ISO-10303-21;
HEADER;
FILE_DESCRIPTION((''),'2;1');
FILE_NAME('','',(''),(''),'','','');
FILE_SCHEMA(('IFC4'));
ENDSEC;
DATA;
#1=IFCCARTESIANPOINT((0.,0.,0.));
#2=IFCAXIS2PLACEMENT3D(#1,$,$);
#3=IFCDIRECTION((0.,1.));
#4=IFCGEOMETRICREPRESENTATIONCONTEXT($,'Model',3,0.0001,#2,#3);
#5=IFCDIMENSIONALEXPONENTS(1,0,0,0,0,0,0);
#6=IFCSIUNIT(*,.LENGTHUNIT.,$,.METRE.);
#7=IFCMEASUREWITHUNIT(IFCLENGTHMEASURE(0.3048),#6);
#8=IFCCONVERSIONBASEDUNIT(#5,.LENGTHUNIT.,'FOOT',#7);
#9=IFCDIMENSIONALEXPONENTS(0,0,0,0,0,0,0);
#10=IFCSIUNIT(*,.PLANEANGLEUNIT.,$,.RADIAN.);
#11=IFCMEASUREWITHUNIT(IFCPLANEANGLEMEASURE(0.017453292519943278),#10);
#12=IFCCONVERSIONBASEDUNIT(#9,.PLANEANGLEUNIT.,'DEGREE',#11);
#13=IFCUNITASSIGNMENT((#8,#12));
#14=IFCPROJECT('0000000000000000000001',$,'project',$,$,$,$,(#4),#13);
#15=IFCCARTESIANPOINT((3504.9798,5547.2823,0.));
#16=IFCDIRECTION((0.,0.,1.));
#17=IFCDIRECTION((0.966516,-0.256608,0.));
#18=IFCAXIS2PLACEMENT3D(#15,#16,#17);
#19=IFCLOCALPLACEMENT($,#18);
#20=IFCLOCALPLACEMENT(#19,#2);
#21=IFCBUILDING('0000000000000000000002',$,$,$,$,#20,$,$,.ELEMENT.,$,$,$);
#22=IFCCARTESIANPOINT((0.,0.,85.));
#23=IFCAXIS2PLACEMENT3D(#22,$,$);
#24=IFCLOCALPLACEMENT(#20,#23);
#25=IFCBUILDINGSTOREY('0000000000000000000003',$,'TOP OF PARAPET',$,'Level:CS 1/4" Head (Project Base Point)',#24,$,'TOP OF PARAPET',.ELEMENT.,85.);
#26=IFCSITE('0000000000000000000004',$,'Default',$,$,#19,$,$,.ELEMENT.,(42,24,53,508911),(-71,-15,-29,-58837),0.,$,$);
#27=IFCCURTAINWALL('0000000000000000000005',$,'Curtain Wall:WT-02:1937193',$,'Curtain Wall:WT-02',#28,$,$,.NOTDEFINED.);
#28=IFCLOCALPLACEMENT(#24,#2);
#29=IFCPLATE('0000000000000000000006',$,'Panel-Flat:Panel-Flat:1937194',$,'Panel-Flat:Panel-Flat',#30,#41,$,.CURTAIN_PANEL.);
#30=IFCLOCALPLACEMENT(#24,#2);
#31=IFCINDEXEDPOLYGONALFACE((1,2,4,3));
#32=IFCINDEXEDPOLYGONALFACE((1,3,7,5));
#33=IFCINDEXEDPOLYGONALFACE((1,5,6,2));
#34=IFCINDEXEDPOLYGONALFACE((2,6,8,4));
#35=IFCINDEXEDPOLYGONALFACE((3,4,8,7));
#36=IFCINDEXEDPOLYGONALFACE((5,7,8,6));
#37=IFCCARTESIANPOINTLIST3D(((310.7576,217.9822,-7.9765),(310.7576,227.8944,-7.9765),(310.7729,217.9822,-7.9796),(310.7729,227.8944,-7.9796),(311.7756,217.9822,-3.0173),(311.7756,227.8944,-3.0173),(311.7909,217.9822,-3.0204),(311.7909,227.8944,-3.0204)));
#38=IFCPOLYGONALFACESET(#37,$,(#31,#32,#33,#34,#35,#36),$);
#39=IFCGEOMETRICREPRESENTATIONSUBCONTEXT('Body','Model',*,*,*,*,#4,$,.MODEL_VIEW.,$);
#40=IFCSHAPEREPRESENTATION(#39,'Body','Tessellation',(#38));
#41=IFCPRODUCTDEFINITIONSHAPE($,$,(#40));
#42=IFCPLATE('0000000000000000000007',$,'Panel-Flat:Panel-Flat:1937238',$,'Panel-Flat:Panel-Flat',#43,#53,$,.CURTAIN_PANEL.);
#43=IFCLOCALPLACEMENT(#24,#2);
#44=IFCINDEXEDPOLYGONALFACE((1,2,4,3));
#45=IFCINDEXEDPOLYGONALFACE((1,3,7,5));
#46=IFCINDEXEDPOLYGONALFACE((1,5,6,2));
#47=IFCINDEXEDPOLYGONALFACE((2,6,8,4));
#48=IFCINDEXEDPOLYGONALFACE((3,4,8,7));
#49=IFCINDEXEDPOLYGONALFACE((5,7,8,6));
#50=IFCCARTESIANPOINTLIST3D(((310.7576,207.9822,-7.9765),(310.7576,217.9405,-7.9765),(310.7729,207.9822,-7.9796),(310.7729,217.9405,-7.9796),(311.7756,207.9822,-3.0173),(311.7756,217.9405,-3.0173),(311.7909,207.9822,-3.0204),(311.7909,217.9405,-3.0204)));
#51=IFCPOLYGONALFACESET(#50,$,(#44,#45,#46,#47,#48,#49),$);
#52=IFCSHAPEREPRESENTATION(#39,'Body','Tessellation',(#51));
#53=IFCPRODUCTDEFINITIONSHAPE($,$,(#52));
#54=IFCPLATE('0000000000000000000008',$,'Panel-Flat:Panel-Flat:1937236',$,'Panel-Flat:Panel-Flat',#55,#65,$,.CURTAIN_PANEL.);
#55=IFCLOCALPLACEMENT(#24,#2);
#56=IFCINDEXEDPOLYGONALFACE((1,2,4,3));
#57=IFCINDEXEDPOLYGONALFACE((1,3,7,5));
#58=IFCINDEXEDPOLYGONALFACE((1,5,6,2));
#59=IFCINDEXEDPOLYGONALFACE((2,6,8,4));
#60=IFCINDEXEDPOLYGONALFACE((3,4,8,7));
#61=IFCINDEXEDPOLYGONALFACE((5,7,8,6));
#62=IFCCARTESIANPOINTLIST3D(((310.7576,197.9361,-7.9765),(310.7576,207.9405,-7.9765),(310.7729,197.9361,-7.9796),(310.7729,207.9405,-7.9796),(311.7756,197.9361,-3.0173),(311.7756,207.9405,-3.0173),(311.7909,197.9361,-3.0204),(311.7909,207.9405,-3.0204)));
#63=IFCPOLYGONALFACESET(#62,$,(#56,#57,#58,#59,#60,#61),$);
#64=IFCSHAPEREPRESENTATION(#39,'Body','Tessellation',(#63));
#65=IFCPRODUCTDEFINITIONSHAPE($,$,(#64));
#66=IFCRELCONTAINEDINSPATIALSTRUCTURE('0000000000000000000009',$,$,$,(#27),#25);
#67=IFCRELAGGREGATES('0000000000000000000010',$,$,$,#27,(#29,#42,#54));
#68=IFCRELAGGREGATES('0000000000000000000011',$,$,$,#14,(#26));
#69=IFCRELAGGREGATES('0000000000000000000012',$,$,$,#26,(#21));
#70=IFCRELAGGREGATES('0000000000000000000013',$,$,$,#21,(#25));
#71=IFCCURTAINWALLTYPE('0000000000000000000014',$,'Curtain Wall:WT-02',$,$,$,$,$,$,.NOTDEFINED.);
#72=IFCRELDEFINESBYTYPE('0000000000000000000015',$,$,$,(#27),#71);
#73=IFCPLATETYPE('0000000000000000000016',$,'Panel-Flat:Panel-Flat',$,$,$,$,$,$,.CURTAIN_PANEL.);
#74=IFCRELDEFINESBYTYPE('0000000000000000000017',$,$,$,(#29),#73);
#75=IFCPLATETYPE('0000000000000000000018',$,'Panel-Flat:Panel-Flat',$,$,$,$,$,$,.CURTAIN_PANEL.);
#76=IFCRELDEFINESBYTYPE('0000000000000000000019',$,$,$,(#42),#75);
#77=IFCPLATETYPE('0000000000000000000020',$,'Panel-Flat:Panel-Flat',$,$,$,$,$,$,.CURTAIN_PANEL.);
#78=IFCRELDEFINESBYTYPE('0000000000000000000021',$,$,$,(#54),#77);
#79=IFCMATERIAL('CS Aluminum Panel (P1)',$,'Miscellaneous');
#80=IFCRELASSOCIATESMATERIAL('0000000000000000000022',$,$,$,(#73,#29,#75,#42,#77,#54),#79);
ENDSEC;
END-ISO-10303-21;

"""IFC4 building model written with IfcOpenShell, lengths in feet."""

from ifc_helpers import new_model, entity, si_unit, converted_unit, direction, frame, origin, place, context, subcontext, project, spatial, indexed_curve, outline, extrude, source, transform, mapped, material, type_object, type_shapes, element, aggregate, save


model = new_model("IFC4")

# Units and contexts
model_context = context("Model", 3, precision=0.0001, world=origin(), true_north=direction((0.0, 1.0)))
body_context = subcontext(model_context, "Body", "Model", "MODEL_VIEW")
ifc_project = project(units=[converted_unit("LENGTHUNIT", "FOOT", entity("IfcLengthMeasure", 0.3048), si_unit("LENGTHUNIT", "METRE"), dimensions=[1, 0, 0, 0, 0, 0, 0]), converted_unit("PLANEANGLEUNIT", "DEGREE", entity("IfcPlaneAngleMeasure", 0.017453292519943278), si_unit("PLANEANGLEUNIT", "RADIAN"), dimensions=[0, 0, 0, 0, 0, 0, 0])], contexts=[model_context])

# Site, building, storey
site_placement = place(None, frame((3504.9798, 5547.2823, 0.0), z_axis=(0.0, 0.0, 1.0), x_axis=(0.966516, -0.256608, 0.0)))
site = spatial("IfcSite", under=ifc_project, at=site_placement, Name="Default", CompositionType="ELEMENT", RefLatitude=(42, 24, 53, 508911), RefLongitude=(-71, -15, -29, -58837), RefElevation=0.0)
building_placement = place(site_placement, origin())
building = spatial("IfcBuilding", under=site, at=building_placement, CompositionType="ELEMENT")
storey_placement = place(building_placement, frame((0.0, 0.0, 85.0)))
storey = spatial("IfcBuildingStorey", under=building, at=storey_placement, Name="TOP OF PARAPET", ObjectType="Level:CS 1/4\" Head (Project Base Point)", LongName="TOP OF PARAPET", CompositionType="ELEMENT", Elevation=85.0)

# Shared definitions
curtain_wall_type_1 = type_object("IfcCurtainWallType", Name="Curtain Wall:WT-02", PredefinedType="NOTDEFINED")

# Curtain wall, plates
curtain_wall_1_placement = place(storey_placement, frame((0.0, 0.0, -85.0)))
curtain_wall_1 = element("IfcCurtainWall", 1, at=curtain_wall_1_placement, inside=storey, type_object=curtain_wall_type_1, Name="Curtain Wall:WT-02:1937193", ObjectType="Curtain Wall:WT-02", PredefinedType="NOTDEFINED")
ifc_material_1 = material(Name="CS Aluminum Panel (P1)", Category="Miscellaneous")
plate_type_1 = type_object("IfcPlateType", Name="Panel-Flat:Panel-Flat", PredefinedType="CURTAIN_PANEL", material=ifc_material_1)
shared_shape_1 = source(origin(), body_context, "Body", "SweptSolid", [
    extrude(outline(indexed_curve([(-0.0078, -4.9561), (0.0078, -4.9561), (0.0078, 4.9561), (-0.0078, 4.9561), (-0.0078, -4.9561)], self_intersect=False)), frame((0.0, -0.0078, 0.0208), z_axis=(0.0, 0.0, 1.0), x_axis=(0.0, -1.0, 0.0)), (0.0, 0.0, 1.0), 5.0626),
])
type_shapes(plate_type_1, [shared_shape_1])
plate_1_placement = place(curtain_wall_1_placement, frame((310.7687, 222.9383, 77.0), z_axis=(0.201078, 0.0, 0.979575), x_axis=(0.0, -1.0, 0.0)))
plate_1 = element("IfcPlate", 2, at=plate_1_placement, type_object=plate_type_1, material=ifc_material_1, Name="Panel-Flat:Panel-Flat:1937194", ObjectType="Panel-Flat:Panel-Flat", PredefinedType="CURTAIN_PANEL", context=body_context, shape_type="MappedRepresentation", body=[
    mapped(shared_shape_1, transform((0.0, 0.0, 0.0), scale=1.0)),
])
plate_type_2 = type_object("IfcPlateType", Name="Panel-Flat:Panel-Flat", PredefinedType="CURTAIN_PANEL", material=ifc_material_1)
shared_shape_2 = source(origin(), body_context, "Body", "SweptSolid", [
    extrude(outline(indexed_curve([(-0.0078, -4.9792), (0.0078, -4.9792), (0.0078, 4.9792), (-0.0078, 4.9792), (-0.0078, -4.9792)], self_intersect=False)), frame((0.0, -0.0078, 0.0208), z_axis=(0.0, 0.0, 1.0), x_axis=(0.0, -1.0, 0.0)), (0.0, 0.0, 1.0), 5.0626),
])
type_shapes(plate_type_2, [shared_shape_2])
plate_2_placement = place(curtain_wall_1_placement, frame((310.7687, 212.9613, 77.0), z_axis=(0.201078, 0.0, 0.979575), x_axis=(0.0, -1.0, 0.0)))
plate_2 = element("IfcPlate", 3, at=plate_2_placement, type_object=plate_type_2, material=ifc_material_1, Name="Panel-Flat:Panel-Flat:1937238", ObjectType="Panel-Flat:Panel-Flat", PredefinedType="CURTAIN_PANEL", context=body_context, shape_type="MappedRepresentation", body=[
    mapped(shared_shape_2, transform((0.0, 0.0, 0.0), scale=1.0)),
])
plate_type_3 = type_object("IfcPlateType", Name="Panel-Flat:Panel-Flat", PredefinedType="CURTAIN_PANEL", material=ifc_material_1)
shared_shape_3 = source(origin(), body_context, "Body", "SweptSolid", [
    extrude(outline(indexed_curve([(-0.0078, -5.0022), (0.0078, -5.0022), (0.0078, 5.0022), (-0.0078, 5.0022), (-0.0078, -5.0022)], self_intersect=False)), frame((0.0, -0.0078, 0.0208), z_axis=(0.0, 0.0, 1.0), x_axis=(0.0, -1.0, 0.0)), (0.0, 0.0, 1.0), 5.0626),
])
type_shapes(plate_type_3, [shared_shape_3])
plate_3_placement = place(curtain_wall_1_placement, frame((310.7687, 202.9383, 77.0), z_axis=(0.201078, 0.0, 0.979575), x_axis=(0.0, -1.0, 0.0)))
plate_3 = element("IfcPlate", 4, at=plate_3_placement, type_object=plate_type_3, material=ifc_material_1, Name="Panel-Flat:Panel-Flat:1937236", ObjectType="Panel-Flat:Panel-Flat", PredefinedType="CURTAIN_PANEL", context=body_context, shape_type="MappedRepresentation", body=[
    mapped(shared_shape_3, transform((0.0, 0.0, 0.0), scale=1.0)),
])
aggregate(curtain_wall_1, [plate_1, plate_2, plate_3])

save(model, "model.ifc")
